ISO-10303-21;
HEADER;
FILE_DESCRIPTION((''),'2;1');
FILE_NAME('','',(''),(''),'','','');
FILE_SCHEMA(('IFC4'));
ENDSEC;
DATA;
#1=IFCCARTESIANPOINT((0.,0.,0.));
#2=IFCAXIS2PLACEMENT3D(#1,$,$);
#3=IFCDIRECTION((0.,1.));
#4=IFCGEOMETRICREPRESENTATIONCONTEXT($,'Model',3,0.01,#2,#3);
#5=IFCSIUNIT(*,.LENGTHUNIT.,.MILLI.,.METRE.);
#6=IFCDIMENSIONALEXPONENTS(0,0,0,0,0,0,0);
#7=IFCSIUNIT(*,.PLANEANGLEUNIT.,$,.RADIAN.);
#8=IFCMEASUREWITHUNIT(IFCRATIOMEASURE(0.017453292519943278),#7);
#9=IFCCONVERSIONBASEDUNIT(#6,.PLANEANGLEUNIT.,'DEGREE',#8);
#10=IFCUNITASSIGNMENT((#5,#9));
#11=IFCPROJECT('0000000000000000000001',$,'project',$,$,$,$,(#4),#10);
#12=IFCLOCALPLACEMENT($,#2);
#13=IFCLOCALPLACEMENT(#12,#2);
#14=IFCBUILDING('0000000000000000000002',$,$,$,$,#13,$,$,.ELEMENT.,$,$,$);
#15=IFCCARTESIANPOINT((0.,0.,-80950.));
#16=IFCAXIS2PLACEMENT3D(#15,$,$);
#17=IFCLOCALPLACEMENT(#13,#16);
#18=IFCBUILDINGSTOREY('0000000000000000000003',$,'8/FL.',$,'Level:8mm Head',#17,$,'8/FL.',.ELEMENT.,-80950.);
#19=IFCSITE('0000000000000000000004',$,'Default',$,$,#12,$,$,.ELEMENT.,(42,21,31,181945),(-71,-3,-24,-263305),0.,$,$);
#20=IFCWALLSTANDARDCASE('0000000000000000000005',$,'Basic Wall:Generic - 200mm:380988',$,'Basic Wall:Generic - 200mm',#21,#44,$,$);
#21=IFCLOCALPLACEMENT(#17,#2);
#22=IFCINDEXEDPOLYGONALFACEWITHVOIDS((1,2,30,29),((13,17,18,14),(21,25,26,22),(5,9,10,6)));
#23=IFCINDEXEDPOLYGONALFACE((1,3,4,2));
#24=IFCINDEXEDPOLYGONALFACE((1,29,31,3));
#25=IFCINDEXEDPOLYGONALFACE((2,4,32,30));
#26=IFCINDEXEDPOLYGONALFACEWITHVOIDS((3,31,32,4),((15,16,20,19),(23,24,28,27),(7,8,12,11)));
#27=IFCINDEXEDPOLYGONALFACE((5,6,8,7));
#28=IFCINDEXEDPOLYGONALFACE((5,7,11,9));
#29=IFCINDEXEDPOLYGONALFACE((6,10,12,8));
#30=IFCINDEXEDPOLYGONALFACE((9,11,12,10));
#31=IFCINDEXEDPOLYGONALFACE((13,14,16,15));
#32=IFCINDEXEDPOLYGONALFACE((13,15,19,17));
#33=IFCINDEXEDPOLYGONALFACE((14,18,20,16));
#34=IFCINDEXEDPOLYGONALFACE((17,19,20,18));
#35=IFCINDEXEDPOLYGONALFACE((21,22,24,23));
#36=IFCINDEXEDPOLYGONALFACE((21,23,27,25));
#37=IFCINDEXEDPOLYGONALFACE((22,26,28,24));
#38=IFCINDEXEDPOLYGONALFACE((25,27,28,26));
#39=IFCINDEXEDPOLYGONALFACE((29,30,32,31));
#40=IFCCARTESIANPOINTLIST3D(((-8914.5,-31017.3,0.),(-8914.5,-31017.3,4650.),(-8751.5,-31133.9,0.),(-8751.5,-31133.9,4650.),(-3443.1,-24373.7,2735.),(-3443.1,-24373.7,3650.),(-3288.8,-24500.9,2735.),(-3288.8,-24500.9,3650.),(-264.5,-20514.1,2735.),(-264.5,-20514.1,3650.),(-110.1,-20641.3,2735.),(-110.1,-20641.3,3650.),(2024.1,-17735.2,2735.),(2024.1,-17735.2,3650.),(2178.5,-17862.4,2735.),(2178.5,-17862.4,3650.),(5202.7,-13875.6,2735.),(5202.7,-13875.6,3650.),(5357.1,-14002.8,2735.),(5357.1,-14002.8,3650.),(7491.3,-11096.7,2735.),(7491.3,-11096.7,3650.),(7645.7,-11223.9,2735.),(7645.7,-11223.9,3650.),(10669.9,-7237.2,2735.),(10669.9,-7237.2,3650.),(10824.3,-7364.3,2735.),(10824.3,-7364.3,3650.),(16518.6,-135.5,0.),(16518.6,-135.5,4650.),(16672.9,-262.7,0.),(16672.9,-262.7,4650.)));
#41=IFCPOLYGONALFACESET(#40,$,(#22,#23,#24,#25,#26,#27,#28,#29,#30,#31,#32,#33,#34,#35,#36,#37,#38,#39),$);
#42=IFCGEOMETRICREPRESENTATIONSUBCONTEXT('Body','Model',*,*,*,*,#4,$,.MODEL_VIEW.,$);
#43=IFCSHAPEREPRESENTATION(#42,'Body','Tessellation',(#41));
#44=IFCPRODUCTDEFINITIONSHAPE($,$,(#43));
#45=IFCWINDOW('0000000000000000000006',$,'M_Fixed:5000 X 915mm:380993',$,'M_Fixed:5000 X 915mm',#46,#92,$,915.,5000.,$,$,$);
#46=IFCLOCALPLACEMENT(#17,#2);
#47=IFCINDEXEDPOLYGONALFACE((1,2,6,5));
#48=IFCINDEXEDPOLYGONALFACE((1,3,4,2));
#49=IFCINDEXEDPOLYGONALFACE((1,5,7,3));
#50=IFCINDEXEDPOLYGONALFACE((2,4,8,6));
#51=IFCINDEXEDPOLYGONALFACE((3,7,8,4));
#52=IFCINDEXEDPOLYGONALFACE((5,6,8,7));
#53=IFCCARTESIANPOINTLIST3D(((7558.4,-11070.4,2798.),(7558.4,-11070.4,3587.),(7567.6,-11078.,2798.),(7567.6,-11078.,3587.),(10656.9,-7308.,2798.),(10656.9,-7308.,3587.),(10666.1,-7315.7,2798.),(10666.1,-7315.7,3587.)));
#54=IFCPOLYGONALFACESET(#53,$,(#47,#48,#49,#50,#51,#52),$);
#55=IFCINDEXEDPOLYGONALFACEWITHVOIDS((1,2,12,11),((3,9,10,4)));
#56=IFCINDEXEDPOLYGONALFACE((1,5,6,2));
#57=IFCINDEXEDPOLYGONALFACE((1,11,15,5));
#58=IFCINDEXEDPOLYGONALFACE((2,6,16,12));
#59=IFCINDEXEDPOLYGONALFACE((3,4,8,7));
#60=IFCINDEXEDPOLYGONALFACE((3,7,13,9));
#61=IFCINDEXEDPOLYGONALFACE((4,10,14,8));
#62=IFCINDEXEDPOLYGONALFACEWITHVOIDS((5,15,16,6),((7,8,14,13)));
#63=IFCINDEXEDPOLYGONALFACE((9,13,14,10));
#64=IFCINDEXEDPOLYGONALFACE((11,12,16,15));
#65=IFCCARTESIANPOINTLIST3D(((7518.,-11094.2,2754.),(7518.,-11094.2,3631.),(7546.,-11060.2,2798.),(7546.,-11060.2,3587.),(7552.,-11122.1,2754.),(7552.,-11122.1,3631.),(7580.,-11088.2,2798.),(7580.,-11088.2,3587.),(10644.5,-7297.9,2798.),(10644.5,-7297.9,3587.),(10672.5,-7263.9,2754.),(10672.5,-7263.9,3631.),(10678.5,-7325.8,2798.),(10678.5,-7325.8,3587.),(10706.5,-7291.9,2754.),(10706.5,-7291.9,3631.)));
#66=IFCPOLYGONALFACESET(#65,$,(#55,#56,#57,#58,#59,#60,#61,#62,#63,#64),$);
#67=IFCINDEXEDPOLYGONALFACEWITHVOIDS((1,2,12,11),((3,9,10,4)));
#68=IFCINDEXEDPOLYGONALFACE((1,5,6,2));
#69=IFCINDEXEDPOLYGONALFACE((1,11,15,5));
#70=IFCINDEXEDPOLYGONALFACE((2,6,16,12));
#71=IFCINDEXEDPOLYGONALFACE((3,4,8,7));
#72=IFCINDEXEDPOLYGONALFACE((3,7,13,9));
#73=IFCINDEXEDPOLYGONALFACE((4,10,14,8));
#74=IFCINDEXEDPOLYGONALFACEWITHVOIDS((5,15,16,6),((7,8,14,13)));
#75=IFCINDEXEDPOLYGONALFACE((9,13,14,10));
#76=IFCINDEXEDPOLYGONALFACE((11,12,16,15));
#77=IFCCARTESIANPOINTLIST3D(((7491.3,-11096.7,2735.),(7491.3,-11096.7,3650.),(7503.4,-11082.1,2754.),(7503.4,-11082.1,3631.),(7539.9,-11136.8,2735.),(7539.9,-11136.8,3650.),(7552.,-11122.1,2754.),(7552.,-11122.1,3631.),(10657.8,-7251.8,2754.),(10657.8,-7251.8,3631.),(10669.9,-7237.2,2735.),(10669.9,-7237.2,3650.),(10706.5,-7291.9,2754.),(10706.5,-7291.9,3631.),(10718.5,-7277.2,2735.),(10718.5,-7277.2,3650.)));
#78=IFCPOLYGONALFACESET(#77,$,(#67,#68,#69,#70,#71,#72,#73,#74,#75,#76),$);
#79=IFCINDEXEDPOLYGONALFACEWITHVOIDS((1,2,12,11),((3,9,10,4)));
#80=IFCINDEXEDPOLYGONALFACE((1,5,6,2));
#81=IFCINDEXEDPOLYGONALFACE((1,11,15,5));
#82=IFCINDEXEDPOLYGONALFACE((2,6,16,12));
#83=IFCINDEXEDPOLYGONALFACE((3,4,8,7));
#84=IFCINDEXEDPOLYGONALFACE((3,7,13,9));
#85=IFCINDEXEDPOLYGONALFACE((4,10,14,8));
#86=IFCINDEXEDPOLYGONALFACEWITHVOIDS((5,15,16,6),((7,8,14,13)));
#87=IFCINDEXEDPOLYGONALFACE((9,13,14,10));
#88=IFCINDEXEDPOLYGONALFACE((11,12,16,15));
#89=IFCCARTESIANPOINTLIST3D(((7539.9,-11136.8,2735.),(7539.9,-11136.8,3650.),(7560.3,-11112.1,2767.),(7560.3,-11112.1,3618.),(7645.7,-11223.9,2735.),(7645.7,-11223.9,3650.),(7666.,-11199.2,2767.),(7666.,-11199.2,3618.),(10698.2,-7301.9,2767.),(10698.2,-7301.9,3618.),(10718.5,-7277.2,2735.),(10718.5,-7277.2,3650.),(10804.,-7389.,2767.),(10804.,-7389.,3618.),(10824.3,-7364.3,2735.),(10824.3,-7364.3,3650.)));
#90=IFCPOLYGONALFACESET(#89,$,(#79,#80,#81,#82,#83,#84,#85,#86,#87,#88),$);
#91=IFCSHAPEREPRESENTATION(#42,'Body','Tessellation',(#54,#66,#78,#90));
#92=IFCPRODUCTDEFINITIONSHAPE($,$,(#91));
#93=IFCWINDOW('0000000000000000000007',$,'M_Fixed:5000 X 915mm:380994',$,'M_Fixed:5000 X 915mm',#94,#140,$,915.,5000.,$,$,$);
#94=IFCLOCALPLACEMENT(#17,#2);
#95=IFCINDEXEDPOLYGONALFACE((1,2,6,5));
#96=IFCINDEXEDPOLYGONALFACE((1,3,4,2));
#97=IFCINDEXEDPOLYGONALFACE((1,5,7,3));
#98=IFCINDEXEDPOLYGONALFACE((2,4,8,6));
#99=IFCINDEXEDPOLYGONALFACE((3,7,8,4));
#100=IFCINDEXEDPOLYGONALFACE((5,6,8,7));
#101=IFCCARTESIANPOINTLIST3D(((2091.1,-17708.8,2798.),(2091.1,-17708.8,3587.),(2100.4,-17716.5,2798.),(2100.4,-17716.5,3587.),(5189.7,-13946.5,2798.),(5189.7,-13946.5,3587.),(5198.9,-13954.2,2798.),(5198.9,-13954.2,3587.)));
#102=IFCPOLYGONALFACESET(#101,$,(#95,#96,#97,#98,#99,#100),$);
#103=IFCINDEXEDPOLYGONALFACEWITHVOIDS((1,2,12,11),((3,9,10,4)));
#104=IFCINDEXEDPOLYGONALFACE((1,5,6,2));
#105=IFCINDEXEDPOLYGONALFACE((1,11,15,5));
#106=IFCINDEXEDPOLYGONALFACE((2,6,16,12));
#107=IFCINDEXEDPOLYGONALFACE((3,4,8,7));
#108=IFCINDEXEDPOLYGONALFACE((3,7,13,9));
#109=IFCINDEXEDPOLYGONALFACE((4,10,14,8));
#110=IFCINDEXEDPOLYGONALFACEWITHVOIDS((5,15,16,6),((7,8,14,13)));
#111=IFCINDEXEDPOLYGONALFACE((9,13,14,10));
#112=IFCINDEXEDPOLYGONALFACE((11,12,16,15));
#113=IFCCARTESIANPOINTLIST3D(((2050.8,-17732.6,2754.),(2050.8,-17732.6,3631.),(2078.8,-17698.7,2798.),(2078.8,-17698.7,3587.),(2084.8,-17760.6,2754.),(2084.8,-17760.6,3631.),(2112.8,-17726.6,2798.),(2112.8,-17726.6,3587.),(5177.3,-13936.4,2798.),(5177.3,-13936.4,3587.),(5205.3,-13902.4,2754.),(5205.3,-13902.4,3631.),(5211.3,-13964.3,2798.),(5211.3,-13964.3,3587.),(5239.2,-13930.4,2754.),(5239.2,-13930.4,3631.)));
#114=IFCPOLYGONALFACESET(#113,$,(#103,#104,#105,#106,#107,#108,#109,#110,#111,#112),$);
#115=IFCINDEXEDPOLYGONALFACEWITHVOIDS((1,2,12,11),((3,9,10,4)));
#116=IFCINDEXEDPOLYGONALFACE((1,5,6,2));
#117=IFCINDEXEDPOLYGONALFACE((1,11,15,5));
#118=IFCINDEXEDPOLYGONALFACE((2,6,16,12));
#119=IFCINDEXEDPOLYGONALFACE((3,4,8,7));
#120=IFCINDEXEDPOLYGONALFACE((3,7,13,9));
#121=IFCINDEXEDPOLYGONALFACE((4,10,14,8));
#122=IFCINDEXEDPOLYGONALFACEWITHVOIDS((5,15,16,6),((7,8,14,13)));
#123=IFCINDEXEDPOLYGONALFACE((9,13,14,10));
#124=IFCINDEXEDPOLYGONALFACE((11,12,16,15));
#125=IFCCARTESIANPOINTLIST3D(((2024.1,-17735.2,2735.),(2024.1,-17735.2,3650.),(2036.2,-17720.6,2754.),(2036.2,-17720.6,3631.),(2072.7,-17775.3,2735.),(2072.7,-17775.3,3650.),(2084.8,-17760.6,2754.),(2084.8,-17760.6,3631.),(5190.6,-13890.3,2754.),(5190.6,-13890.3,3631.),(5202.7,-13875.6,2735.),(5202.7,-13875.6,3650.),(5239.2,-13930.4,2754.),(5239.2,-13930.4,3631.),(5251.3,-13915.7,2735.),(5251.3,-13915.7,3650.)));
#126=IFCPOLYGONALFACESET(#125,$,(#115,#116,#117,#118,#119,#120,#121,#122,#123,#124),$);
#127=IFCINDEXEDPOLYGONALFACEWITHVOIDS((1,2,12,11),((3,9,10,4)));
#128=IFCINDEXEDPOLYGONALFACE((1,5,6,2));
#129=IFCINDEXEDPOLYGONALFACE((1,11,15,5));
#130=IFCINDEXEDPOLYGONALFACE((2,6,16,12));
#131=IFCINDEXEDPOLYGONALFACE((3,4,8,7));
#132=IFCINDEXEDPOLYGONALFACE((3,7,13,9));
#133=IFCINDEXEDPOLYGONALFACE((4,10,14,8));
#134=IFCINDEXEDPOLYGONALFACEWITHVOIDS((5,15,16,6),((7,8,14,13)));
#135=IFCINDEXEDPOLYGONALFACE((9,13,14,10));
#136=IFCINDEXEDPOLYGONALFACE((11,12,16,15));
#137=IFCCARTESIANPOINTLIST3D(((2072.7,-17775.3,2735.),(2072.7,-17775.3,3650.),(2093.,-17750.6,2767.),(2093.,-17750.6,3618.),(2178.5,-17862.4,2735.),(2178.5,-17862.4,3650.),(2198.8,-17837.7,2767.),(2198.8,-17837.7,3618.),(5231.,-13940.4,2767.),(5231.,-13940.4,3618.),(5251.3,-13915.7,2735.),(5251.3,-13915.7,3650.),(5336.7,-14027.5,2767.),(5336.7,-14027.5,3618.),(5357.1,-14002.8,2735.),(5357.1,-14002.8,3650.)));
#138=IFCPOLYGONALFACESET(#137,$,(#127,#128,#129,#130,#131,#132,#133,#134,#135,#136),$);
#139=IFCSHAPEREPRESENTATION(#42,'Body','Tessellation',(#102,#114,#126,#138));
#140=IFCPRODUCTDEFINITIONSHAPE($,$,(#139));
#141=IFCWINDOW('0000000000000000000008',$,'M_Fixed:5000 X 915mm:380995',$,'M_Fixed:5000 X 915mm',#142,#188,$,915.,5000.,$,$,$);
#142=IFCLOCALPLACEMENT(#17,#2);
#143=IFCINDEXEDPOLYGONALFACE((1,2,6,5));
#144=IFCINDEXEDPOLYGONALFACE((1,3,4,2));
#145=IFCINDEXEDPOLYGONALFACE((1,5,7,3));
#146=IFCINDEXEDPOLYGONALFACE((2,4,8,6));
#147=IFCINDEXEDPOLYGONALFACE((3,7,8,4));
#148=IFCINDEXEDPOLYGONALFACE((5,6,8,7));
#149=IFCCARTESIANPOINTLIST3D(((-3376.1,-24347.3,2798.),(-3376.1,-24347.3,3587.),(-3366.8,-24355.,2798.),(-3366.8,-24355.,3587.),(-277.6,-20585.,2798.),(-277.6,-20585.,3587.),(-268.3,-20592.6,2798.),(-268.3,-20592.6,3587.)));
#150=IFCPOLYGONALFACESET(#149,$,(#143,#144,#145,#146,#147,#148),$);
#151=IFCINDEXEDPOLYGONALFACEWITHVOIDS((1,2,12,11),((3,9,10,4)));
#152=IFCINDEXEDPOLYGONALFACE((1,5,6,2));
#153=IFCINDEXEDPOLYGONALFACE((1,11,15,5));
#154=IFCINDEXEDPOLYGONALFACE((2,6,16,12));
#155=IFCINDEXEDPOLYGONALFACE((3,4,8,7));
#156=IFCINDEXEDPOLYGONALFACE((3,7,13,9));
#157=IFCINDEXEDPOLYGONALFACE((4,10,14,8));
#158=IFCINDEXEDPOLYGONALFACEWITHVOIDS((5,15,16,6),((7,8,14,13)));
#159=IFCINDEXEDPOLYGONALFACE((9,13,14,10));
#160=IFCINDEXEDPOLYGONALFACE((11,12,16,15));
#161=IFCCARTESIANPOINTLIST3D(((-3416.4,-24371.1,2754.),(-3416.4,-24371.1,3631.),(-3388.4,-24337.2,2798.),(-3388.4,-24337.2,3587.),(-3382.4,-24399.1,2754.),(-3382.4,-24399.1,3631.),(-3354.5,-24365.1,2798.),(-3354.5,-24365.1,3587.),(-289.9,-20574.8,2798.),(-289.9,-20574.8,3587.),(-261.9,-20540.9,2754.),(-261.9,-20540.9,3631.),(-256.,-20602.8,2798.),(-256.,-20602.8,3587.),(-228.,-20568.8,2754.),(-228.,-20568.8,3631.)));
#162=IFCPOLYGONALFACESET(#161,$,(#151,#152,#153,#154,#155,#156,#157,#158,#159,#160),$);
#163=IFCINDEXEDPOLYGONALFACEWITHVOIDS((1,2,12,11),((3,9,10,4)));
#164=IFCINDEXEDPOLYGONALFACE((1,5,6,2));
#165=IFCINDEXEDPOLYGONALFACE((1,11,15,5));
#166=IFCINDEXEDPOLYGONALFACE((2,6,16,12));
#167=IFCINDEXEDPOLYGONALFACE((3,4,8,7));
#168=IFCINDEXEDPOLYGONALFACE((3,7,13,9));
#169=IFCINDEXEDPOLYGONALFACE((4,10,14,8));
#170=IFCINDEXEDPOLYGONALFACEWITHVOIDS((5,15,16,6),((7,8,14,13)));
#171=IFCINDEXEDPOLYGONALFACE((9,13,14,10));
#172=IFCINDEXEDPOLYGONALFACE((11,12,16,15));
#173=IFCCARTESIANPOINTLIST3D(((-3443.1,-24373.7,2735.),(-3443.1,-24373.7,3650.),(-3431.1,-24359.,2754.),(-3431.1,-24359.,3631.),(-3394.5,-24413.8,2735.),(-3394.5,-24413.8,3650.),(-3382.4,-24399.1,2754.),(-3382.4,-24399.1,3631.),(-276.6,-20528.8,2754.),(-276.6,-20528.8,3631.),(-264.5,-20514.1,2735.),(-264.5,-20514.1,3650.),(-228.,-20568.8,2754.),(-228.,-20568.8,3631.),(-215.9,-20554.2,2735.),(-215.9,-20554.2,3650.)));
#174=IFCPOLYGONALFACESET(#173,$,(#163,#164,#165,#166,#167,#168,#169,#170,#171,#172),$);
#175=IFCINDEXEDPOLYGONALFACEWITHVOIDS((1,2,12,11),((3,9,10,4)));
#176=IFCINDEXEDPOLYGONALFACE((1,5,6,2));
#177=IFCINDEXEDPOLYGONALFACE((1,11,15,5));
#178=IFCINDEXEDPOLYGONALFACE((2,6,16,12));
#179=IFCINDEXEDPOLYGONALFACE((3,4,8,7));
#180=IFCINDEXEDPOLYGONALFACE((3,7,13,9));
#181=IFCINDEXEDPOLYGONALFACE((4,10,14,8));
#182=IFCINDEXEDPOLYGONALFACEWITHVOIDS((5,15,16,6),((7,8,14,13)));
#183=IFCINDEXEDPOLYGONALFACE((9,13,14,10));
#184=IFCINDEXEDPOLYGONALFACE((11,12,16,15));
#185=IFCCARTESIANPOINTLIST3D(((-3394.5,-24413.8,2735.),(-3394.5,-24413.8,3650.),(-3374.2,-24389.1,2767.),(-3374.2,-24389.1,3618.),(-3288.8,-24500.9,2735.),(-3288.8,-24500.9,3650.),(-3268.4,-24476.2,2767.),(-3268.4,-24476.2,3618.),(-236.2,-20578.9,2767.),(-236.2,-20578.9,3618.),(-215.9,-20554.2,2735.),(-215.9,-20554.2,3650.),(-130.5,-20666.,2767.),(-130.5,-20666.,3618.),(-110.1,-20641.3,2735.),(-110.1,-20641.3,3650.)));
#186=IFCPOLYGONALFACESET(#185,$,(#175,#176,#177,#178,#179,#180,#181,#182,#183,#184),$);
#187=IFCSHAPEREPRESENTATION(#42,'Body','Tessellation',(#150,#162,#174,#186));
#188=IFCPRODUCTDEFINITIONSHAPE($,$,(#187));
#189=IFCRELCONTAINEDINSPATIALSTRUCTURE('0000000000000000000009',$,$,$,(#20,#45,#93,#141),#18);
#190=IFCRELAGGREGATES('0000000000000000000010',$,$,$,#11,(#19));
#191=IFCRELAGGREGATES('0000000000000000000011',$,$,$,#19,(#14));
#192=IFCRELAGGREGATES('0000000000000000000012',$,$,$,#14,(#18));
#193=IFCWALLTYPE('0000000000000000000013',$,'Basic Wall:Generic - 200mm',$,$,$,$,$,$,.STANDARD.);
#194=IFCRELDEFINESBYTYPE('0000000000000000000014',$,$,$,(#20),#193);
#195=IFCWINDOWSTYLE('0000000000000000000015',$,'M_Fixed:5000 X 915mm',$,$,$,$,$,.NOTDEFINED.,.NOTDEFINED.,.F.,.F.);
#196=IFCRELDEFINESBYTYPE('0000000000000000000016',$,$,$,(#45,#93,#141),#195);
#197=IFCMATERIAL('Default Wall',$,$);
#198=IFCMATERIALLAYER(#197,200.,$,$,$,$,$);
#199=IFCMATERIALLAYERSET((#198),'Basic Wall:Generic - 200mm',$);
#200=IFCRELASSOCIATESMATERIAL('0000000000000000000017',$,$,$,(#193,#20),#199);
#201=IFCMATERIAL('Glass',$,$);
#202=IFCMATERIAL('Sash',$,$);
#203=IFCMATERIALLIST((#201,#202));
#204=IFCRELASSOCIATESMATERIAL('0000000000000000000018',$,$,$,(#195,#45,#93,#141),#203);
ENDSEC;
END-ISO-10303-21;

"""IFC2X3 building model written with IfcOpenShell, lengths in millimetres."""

from ifc_helpers import new_model, entity, si_unit, converted_unit, direction, frame, frame_2d, origin, place, context, subcontext, project, spatial, polyline, rectangle, outline, extrude, source, transform, mapped, material, material_list, layer, layer_set, layer_usage, type_object, type_shapes, element, fill, save


model = new_model("IFC2X3")

# Units and contexts
model_context = context("Model", 3, precision=0.01, world=origin(), true_north=direction((0.0, 1.0)))
body_context = subcontext(model_context, "Body", "Model", "MODEL_VIEW")
ifc_project = project(units=[si_unit("LENGTHUNIT", "METRE", prefix="MILLI"), converted_unit("PLANEANGLEUNIT", "DEGREE", entity("IfcRatioMeasure", 0.017453292519943278), si_unit("PLANEANGLEUNIT", "RADIAN"), dimensions=[0, 0, 0, 0, 0, 0, 0])], contexts=[model_context])

# Site, building, storey
site_placement = place(None, origin())
site = spatial("IfcSite", under=ifc_project, at=site_placement, Name="Default", CompositionType="ELEMENT", RefLatitude=(42, 21, 31, 181945), RefLongitude=(-71, -3, -24, -263305), RefElevation=0.0)
building_placement = place(site_placement, origin())
building = spatial("IfcBuilding", under=site, at=building_placement, CompositionType="ELEMENT")
storey_placement = place(building_placement, frame((0.0, 0.0, -80950.0)))
storey = spatial("IfcBuildingStorey", under=building, at=storey_placement, Name="8/FL.", ObjectType="Level:8mm Head", LongName="8/FL.", CompositionType="ELEMENT", Elevation=-80950.0)

# Shared definitions
ifc_material_1 = material(Name="Default Wall")
ifc_layer = layer(ifc_material_1, 200.0)
ifc_layer_set = layer_set([ifc_layer], Name="Basic Wall:Generic - 200mm")
ifc_layer_usage = layer_usage(ifc_layer_set, "AXIS2", "NEGATIVE", 100.0)
wall_type = type_object("IfcWallType", Name="Basic Wall:Generic - 200mm", PredefinedType="STANDARD", material=ifc_layer_set)

# Wall, openings, windows
wall_1_placement = place(storey_placement, frame((17104.3, 418.4, 0.0), z_axis=(0.0, 0.0, 1.0), x_axis=(-0.635723, -0.771917, 0.0)))
wall_1 = element("IfcWallStandardCase", 1, at=wall_1_placement, inside=storey, type_object=wall_type, material=ifc_layer_usage, Name="Basic Wall:Generic - 200mm:380988", ObjectType="Basic Wall:Generic - 200mm", context=body_context, shape_type="SweptSolid", body=[
    extrude(outline(polyline([(40806.5, -100.0), (40793.0, 100.0), (37219.3, 100.0), (37019.3, 100.0), (800.0, 100.0), (800.0, -100.0), (37019.3, -100.0), (37219.3, -100.0), (40806.5, -100.0)])), origin(), (0.0, 0.0, 1.0), 4650.0),
])
opening_1_placement = place(wall_1_placement, origin())
element("IfcOpeningElement", 2, at=opening_1_placement, cuts=wall_1, ObjectType="Opening", context=body_context, shape_type="SweptSolid", body=[
    extrude(rectangle(XDim=1000.0, YDim=1012.7, at=frame_2d((0.0, 0.0), x_axis=(1.0, 0.0))), frame((293.7, -183.3, 500.0), z_axis=(0.0, 1.0, 0.0), x_axis=(0.0, 0.0, -1.0)), (0.0, 0.0, 1.0), 1010.1),
])
opening_2_placement = place(wall_1_placement, frame((15000.0, 100.0, 2735.0)))
opening_2 = element("IfcOpeningElement", 3, at=opening_2_placement, cuts=wall_1, ObjectType="Opening", context=body_context, shape_type="SweptSolid", body=[
    extrude(rectangle(XDim=915.0, YDim=5000.0, at=frame_2d((457.5, 2500.0), x_axis=(1.0, 0.0))), frame((0.0, 0.0, 0.0), z_axis=(0.0, -1.0, 0.0), x_axis=(0.0, 0.0, 1.0)), (0.0, 0.0, 1.0), 200.0),
])
opening_3_placement = place(wall_1_placement, frame((23600.0, 100.0, 2735.0)))
opening_3 = element("IfcOpeningElement", 4, at=opening_3_placement, cuts=wall_1, ObjectType="Opening", context=body_context, shape_type="SweptSolid", body=[
    extrude(rectangle(XDim=915.0, YDim=5000.0, at=frame_2d((457.5, 2500.0), x_axis=(1.0, 0.0))), frame((0.0, 0.0, 0.0), z_axis=(0.0, -1.0, 0.0), x_axis=(0.0, 0.0, 1.0)), (0.0, 0.0, 1.0), 200.0),
])
opening_4_placement = place(wall_1_placement, frame((32200.0, 100.0, 2735.0)))
opening_4 = element("IfcOpeningElement", 5, at=opening_4_placement, cuts=wall_1, ObjectType="Opening", context=body_context, shape_type="SweptSolid", body=[
    extrude(rectangle(XDim=915.0, YDim=5000.0, at=frame_2d((457.5, 2500.0), x_axis=(1.0, 0.0))), frame((0.0, 0.0, 0.0), z_axis=(0.0, -1.0, 0.0), x_axis=(0.0, 0.0, 1.0)), (0.0, 0.0, 1.0), 200.0),
])
ifc_material_2 = material(Name="Glass")
ifc_material_3 = material(Name="Sash")
ifc_material_list = material_list([ifc_material_2, ifc_material_3])
window_style_1 = type_object("IfcWindowStyle", Name="M_Fixed:5000 X 915mm", ConstructionType="NOTDEFINED", OperationType="NOTDEFINED", ParameterTakesPrecedence=False, Sizeable=False, material=ifc_material_list)
shared_shape_1 = source(origin(), body_context, "Body", "SweptSolid", [
    extrude(rectangle(XDim=12.0, YDim=4874.0, at=frame_2d((0.0, 0.0), x_axis=(1.0, 0.0))), frame((2500.0, 159.0, 63.0), z_axis=(0.0, 0.0, 1.0), x_axis=(0.0, -1.0, 0.0)), (0.0, 0.0, 1.0), 789.0),
    extrude(outline(polyline([(-2481.0, -438.5), (2481.0, -438.5), (2481.0, 438.5), (-2481.0, 438.5), (-2481.0, -438.5)]), holes=[polyline([(-2437.0, -394.5), (-2437.0, 394.5), (2437.0, 394.5), (2437.0, -394.5), (-2437.0, -394.5)])]), frame((2500.0, 137.0, 457.5), z_axis=(0.0, 1.0, 0.0), x_axis=(1.0, 0.0, 0.0)), (0.0, 0.0, 1.0), 44.0),
    extrude(outline(polyline([(-2500.0, -457.5), (2500.0, -457.5), (2500.0, 457.5), (-2500.0, 457.5), (-2500.0, -457.5)]), holes=[polyline([(-2481.0, -438.5), (-2481.0, 438.5), (2481.0, 438.5), (2481.0, -438.5), (-2481.0, -438.5)])]), frame((2500.0, 137.0, 457.5), z_axis=(0.0, 1.0, 0.0), x_axis=(1.0, 0.0, 0.0)), (0.0, 0.0, 1.0), 63.0),
    extrude(outline(polyline([(-2500.0, -457.5), (2500.0, -457.5), (2500.0, 457.5), (-2500.0, 457.5), (-2500.0, -457.5)]), holes=[polyline([(-2468.0, -425.5), (-2468.0, 425.5), (2468.0, 425.5), (2468.0, -425.5), (-2468.0, -425.5)])]), frame((2500.0, 0.0, 457.5), z_axis=(0.0, 1.0, 0.0), x_axis=(1.0, 0.0, 0.0)), (0.0, 0.0, 1.0), 137.0),
])
type_shapes(window_style_1, [shared_shape_1])
window_1_placement = place(opening_2_placement, frame((0.0, 0.0, 0.0), z_axis=(0.0, 0.0, 1.0), x_axis=(-1.0, 0.0, 0.0)))
window_1 = element("IfcWindow", 6, at=window_1_placement, inside=storey, type_object=window_style_1, material=ifc_material_list, Name="M_Fixed:5000 X 915mm:380993", ObjectType="M_Fixed:5000 X 915mm", OverallHeight=915.0, OverallWidth=5000.0, context=body_context, shape_type="MappedRepresentation", body=[
    mapped(shared_shape_1, transform((0.0, 0.0, 0.0), scale=1.0)),
])
fill(opening_2, window_1)
window_2_placement = place(opening_3_placement, frame((0.0, 0.0, 0.0), z_axis=(0.0, 0.0, 1.0), x_axis=(-1.0, 0.0, 0.0)))
window_2 = element("IfcWindow", 7, at=window_2_placement, inside=storey, type_object=window_style_1, material=ifc_material_list, Name="M_Fixed:5000 X 915mm:380994", ObjectType="M_Fixed:5000 X 915mm", OverallHeight=915.0, OverallWidth=5000.0, context=body_context, shape_type="MappedRepresentation", body=[
    mapped(shared_shape_1, transform((0.0, 0.0, 0.0), scale=1.0)),
])
fill(opening_3, window_2)
window_3_placement = place(opening_4_placement, frame((0.0, 0.0, 0.0), z_axis=(0.0, 0.0, 1.0), x_axis=(-1.0, 0.0, 0.0)))
window_3 = element("IfcWindow", 8, at=window_3_placement, inside=storey, type_object=window_style_1, material=ifc_material_list, Name="M_Fixed:5000 X 915mm:380995", ObjectType="M_Fixed:5000 X 915mm", OverallHeight=915.0, OverallWidth=5000.0, context=body_context, shape_type="MappedRepresentation", body=[
    mapped(shared_shape_1, transform((0.0, 0.0, 0.0), scale=1.0)),
])
fill(opening_4, window_3)

save(model, "model.ifc")
